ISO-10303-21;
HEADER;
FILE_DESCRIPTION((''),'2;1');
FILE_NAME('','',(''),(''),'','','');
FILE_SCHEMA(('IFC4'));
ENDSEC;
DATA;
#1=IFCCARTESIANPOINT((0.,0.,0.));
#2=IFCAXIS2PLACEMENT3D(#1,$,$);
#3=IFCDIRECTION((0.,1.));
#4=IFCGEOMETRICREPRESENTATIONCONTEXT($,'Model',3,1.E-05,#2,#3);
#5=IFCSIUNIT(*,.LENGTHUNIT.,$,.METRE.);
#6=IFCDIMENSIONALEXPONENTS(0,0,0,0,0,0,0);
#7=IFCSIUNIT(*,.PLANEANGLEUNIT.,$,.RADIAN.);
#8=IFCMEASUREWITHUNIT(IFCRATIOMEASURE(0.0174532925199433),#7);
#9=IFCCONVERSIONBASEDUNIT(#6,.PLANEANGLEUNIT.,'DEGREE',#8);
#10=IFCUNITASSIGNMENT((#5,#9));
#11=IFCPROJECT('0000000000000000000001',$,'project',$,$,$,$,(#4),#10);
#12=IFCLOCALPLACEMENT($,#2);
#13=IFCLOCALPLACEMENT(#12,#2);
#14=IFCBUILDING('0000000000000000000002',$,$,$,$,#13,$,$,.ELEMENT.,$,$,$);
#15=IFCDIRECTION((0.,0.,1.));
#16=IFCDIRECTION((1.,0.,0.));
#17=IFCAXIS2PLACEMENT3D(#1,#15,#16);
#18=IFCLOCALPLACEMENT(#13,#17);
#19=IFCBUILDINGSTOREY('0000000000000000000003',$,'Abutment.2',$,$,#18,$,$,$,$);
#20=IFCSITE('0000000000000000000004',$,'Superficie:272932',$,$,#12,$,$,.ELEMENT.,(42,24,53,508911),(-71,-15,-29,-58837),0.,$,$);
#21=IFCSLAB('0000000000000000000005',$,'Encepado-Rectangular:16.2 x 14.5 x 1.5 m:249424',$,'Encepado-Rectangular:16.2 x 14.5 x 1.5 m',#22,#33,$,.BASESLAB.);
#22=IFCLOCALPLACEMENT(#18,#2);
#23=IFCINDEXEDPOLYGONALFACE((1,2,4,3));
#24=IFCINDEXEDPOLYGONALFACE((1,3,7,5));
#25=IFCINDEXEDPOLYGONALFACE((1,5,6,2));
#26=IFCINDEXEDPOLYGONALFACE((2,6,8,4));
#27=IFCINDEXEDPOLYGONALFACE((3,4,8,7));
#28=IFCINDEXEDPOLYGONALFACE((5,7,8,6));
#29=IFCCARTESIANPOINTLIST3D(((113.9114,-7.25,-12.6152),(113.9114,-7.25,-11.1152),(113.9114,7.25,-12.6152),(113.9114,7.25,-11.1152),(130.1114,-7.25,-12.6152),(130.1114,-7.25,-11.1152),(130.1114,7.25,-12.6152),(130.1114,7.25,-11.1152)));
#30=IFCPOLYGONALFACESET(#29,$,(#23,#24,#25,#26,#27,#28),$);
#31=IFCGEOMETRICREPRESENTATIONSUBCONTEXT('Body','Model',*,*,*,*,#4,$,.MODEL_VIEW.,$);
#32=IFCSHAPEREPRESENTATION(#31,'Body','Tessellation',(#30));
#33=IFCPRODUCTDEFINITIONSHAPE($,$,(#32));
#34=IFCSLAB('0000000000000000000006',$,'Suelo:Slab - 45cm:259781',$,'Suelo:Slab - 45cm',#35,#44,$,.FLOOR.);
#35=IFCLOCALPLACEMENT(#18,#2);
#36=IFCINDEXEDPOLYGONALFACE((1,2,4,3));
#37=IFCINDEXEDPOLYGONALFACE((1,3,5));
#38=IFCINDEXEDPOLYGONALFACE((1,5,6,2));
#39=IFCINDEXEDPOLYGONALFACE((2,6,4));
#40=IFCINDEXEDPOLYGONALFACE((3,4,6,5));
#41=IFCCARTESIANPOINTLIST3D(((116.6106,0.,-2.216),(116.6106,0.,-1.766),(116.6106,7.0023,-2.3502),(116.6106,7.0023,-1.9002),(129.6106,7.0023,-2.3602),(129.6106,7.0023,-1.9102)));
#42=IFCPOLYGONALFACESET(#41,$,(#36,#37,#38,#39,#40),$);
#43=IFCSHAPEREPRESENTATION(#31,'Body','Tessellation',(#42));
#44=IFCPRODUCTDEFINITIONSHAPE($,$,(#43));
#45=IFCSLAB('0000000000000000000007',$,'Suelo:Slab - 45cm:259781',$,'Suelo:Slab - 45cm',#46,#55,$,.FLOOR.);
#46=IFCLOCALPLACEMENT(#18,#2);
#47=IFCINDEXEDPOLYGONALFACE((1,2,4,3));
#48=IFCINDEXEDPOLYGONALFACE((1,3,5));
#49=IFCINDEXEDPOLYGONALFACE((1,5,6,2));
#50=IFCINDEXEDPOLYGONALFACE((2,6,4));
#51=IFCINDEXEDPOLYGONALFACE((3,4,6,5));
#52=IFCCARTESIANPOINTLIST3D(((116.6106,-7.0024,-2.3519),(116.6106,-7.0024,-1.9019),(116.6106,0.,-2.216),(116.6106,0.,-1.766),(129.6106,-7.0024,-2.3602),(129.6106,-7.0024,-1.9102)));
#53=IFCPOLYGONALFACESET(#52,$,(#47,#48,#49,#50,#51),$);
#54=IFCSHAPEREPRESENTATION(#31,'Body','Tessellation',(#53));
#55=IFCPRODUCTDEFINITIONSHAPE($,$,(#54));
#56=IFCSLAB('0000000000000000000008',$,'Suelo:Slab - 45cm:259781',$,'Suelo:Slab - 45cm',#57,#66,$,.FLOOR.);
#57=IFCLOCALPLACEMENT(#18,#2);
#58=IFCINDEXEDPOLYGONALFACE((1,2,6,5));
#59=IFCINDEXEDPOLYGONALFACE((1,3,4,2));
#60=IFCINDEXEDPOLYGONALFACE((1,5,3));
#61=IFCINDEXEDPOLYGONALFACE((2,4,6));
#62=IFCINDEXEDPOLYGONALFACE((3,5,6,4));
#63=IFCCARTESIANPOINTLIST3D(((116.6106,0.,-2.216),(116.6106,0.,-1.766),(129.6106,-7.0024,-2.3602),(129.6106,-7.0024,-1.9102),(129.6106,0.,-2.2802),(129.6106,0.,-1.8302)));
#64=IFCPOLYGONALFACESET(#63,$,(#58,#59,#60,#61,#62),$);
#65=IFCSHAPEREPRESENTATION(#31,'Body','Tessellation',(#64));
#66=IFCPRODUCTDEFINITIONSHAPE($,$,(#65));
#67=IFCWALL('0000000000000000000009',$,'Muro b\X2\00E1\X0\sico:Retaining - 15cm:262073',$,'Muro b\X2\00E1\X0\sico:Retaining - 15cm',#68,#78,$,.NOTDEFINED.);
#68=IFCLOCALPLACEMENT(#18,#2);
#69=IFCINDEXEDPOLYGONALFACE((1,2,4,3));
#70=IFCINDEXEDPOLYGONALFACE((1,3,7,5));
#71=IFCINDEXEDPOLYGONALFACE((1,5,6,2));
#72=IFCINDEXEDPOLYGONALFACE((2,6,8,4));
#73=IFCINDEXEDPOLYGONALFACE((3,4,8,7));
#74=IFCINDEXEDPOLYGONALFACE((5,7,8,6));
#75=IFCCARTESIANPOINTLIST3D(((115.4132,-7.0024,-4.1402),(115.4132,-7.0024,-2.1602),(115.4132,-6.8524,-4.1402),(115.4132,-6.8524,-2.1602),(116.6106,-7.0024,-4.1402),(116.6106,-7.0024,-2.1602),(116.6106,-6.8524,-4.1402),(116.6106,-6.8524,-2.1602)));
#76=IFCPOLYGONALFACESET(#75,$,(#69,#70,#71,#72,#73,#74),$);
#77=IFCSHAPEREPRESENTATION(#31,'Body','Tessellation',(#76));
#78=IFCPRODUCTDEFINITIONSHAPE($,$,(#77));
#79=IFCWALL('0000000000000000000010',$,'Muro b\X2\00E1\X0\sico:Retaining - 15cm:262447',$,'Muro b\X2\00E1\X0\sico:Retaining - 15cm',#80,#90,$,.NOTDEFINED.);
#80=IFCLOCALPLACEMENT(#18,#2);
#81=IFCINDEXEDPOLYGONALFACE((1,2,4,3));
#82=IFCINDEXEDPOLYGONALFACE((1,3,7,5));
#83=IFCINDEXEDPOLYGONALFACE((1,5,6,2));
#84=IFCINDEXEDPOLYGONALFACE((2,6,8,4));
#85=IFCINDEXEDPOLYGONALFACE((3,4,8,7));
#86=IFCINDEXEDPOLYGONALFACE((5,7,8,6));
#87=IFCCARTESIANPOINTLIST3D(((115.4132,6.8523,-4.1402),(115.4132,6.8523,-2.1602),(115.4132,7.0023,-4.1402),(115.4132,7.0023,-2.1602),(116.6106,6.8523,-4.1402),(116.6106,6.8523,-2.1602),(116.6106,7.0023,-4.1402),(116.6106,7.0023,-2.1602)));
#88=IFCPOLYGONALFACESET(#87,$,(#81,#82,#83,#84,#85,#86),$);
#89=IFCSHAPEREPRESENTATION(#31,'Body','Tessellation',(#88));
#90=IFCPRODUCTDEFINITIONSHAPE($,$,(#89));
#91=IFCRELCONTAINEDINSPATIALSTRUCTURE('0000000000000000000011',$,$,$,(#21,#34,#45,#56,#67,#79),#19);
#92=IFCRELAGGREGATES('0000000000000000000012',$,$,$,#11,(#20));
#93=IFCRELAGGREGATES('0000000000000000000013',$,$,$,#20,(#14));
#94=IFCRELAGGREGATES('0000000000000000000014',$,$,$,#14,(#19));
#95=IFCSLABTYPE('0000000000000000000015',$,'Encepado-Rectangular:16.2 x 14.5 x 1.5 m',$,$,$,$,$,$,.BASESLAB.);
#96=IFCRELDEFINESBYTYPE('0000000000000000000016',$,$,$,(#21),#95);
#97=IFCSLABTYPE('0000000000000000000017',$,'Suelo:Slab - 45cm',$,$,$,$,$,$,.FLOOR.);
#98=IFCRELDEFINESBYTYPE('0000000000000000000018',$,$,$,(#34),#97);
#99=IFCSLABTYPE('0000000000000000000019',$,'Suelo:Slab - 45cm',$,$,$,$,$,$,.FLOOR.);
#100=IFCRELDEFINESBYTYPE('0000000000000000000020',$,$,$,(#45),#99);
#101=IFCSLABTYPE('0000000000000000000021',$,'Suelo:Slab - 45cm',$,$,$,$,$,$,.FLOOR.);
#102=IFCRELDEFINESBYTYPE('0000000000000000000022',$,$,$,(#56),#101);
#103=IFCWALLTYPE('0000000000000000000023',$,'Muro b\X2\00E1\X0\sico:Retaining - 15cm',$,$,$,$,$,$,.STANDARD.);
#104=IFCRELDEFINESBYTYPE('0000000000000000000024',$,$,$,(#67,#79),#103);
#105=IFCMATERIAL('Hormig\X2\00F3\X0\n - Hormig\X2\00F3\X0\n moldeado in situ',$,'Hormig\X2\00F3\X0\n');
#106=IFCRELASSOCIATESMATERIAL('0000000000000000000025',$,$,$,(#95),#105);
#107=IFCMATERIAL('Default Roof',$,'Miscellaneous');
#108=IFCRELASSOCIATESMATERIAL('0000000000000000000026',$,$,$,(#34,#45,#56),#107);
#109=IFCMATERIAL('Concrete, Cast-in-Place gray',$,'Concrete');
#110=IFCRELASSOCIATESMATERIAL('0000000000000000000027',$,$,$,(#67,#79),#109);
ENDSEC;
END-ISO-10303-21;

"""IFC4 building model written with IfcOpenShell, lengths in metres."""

from ifc_helpers import new_model, entity, si_unit, converted_unit, direction, frame, origin, origin_with_axes, place, context, subcontext, project, spatial, indexed_curve, outline, extrude, material, type_object, element, save


model = new_model("IFC4")

# Units and contexts
model_context = context("Model", 3, precision=1e-05, world=origin(), true_north=direction((0.0, 1.0)))
body_context = subcontext(model_context, "Body", "Model", "MODEL_VIEW")
ifc_project = project(units=[si_unit("LENGTHUNIT", "METRE"), converted_unit("PLANEANGLEUNIT", "DEGREE", entity("IfcRatioMeasure", 0.0174532925199433), si_unit("PLANEANGLEUNIT", "RADIAN"), dimensions=[0, 0, 0, 0, 0, 0, 0])], contexts=[model_context])

# Site, building, storey
site_placement = place(None, origin())
site = spatial("IfcSite", under=ifc_project, at=site_placement, Name="Superficie:272932", CompositionType="ELEMENT", RefLatitude=(42, 24, 53, 508911), RefLongitude=(-71, -15, -29, -58837), RefElevation=0.0)
building_placement = place(site_placement, origin())
building = spatial("IfcBuilding", under=site, at=building_placement, CompositionType="ELEMENT")
storey_placement = place(building_placement, origin_with_axes())
storey = spatial("IfcBuildingStorey", under=building, at=storey_placement, Name="Abutment.2")

# Slabs
ifc_material_1 = material(Name="Hormigón - Hormigón moldeado in situ", Category="Hormigón")
slab_type_1 = type_object("IfcSlabType", Name="Encepado-Rectangular:16.2 x 14.5 x 1.5 m", PredefinedType="BASESLAB", material=ifc_material_1)
slab_1_placement = place(storey_placement, frame((0.0, 0.0, -11.1152), z_axis=(0.0, 0.0, 1.0), x_axis=(1.0, 0.0, 0.0)))
element("IfcSlab", 1, at=slab_1_placement, inside=storey, type_object=slab_type_1, Name="Encepado-Rectangular:16.2 x 14.5 x 1.5 m:249424", ObjectType="Encepado-Rectangular:16.2 x 14.5 x 1.5 m", PredefinedType="BASESLAB", context=body_context, shape_type="SweptSolid", body=[
    extrude(outline(indexed_curve([(-8.1, -7.25), (8.1, -7.25), (8.1, 7.25), (-8.1, 7.25), (-8.1, -7.25)], self_intersect=False)), frame((122.0114, 0.0, -1.5), z_axis=(0.0, 0.0, 1.0), x_axis=(-1.0, 0.0, 0.0)), (0.0, 0.0, 1.0), 1.5),
])
ifc_material_2 = material(Name="Default Roof", Category="Miscellaneous")
slab_type_2 = type_object("IfcSlabType", Name="Suelo:Slab - 45cm", PredefinedType="FLOOR")
slab_2_placement = place(storey_placement, frame((116.6106, -7.0024, -2.3602), z_axis=(0.0, 0.0, 1.0), x_axis=(1.0, 0.0, 0.0)))
element("IfcSlab", 2, at=slab_2_placement, inside=storey, type_object=slab_type_2, material=ifc_material_2, Name="Suelo:Slab - 45cm:259781", ObjectType="Suelo:Slab - 45cm", PredefinedType="FLOOR", context=body_context, shape_type="SweptSolid", body=[
    extrude(outline(indexed_curve([(6.5, 3.5019), (-6.5, 3.5017), (-6.5, -3.5019), (6.5, 3.5019)], self_intersect=False)), frame((6.5, 10.5035, 0.5221), z_axis=(0.000769, 0.019155, 0.999816), x_axis=(1.0, -0.000015, -0.000769)), (0.000769, 0.019155, -0.999816), 0.45),
])
slab_type_3 = type_object("IfcSlabType", Name="Suelo:Slab - 45cm", PredefinedType="FLOOR")
slab_3_placement = place(storey_placement, frame((116.6106, -7.0024, -2.3602), z_axis=(0.0, 0.0, 1.0), x_axis=(1.0, 0.0, 0.0)))
element("IfcSlab", 3, at=slab_3_placement, inside=storey, type_object=slab_type_3, material=ifc_material_2, Name="Suelo:Slab - 45cm:259781", ObjectType="Suelo:Slab - 45cm", PredefinedType="FLOOR", context=body_context, shape_type="SweptSolid", body=[
    extrude(outline(indexed_curve([(-6.5, -3.5018), (6.5, -3.5019), (-6.5, 3.5019), (-6.5, -3.5018)], self_intersect=False)), frame((6.5, 3.5012, 0.5221), z_axis=(0.000635, -0.019403, 0.999812), x_axis=(1.0, 0.000012, -0.000635)), (0.000635, -0.019403, -0.999812), 0.45),
])
slab_type_4 = type_object("IfcSlabType", Name="Suelo:Slab - 45cm", PredefinedType="FLOOR")
slab_4_placement = place(storey_placement, frame((116.6106, -7.0024, -2.3602), z_axis=(0.0, 0.0, 1.0), x_axis=(1.0, 0.0, 0.0)))
element("IfcSlab", 4, at=slab_4_placement, inside=storey, type_object=slab_type_4, material=ifc_material_2, Name="Suelo:Slab - 45cm:259781", ObjectType="Suelo:Slab - 45cm", PredefinedType="FLOOR", context=body_context, shape_type="SweptSolid", body=[
    extrude(outline(indexed_curve([(6.5001, -3.5018), (6.5001, 3.501), (-6.5001, 3.5018), (6.5001, -3.5018)], self_intersect=False)), frame((6.5, 3.5012, 0.5221), z_axis=(0.004934, -0.011424, 0.999923), x_axis=(0.999988, 0.000056, -0.004934)), (0.004934, -0.011424, -0.999923), 0.45),
])

# Walls
ifc_material_3 = material(Name="Concrete, Cast-in-Place gray", Category="Concrete")
wall_type = type_object("IfcWallType", Name="Muro básico:Retaining - 15cm", PredefinedType="STANDARD")
wall_1_placement = place(storey_placement, frame((115.4132, -6.9274, -4.1402), z_axis=(0.0, 0.0, 1.0), x_axis=(1.0, 0.0, 0.0)))
element("IfcWall", 5, at=wall_1_placement, inside=storey, type_object=wall_type, material=ifc_material_3, Name="Muro básico:Retaining - 15cm:262073", ObjectType="Muro básico:Retaining - 15cm", PredefinedType="NOTDEFINED", context=body_context, shape_type="SweptSolid", body=[
    extrude(outline(indexed_curve([(1.1974, 0.075), (0.0, 0.075), (0.0, -0.075), (1.1974, -0.075), (1.1974, 0.075)], self_intersect=False)), origin(), (0.0, 0.0, 1.0), 1.98),
])
wall_2_placement = place(storey_placement, frame((115.4132, 6.9273, -4.1402), z_axis=(0.0, 0.0, 1.0), x_axis=(1.0, 0.0, 0.0)))
element("IfcWall", 6, at=wall_2_placement, inside=storey, type_object=wall_type, material=ifc_material_3, Name="Muro básico:Retaining - 15cm:262447", ObjectType="Muro básico:Retaining - 15cm", PredefinedType="NOTDEFINED", context=body_context, shape_type="SweptSolid", body=[
    extrude(outline(indexed_curve([(1.1974, 0.075), (0.0, 0.075), (0.0, -0.075), (1.1974, -0.075), (1.1974, 0.075)], self_intersect=False)), origin(), (0.0, 0.0, 1.0), 1.98),
])

save(model, "model.ifc")
